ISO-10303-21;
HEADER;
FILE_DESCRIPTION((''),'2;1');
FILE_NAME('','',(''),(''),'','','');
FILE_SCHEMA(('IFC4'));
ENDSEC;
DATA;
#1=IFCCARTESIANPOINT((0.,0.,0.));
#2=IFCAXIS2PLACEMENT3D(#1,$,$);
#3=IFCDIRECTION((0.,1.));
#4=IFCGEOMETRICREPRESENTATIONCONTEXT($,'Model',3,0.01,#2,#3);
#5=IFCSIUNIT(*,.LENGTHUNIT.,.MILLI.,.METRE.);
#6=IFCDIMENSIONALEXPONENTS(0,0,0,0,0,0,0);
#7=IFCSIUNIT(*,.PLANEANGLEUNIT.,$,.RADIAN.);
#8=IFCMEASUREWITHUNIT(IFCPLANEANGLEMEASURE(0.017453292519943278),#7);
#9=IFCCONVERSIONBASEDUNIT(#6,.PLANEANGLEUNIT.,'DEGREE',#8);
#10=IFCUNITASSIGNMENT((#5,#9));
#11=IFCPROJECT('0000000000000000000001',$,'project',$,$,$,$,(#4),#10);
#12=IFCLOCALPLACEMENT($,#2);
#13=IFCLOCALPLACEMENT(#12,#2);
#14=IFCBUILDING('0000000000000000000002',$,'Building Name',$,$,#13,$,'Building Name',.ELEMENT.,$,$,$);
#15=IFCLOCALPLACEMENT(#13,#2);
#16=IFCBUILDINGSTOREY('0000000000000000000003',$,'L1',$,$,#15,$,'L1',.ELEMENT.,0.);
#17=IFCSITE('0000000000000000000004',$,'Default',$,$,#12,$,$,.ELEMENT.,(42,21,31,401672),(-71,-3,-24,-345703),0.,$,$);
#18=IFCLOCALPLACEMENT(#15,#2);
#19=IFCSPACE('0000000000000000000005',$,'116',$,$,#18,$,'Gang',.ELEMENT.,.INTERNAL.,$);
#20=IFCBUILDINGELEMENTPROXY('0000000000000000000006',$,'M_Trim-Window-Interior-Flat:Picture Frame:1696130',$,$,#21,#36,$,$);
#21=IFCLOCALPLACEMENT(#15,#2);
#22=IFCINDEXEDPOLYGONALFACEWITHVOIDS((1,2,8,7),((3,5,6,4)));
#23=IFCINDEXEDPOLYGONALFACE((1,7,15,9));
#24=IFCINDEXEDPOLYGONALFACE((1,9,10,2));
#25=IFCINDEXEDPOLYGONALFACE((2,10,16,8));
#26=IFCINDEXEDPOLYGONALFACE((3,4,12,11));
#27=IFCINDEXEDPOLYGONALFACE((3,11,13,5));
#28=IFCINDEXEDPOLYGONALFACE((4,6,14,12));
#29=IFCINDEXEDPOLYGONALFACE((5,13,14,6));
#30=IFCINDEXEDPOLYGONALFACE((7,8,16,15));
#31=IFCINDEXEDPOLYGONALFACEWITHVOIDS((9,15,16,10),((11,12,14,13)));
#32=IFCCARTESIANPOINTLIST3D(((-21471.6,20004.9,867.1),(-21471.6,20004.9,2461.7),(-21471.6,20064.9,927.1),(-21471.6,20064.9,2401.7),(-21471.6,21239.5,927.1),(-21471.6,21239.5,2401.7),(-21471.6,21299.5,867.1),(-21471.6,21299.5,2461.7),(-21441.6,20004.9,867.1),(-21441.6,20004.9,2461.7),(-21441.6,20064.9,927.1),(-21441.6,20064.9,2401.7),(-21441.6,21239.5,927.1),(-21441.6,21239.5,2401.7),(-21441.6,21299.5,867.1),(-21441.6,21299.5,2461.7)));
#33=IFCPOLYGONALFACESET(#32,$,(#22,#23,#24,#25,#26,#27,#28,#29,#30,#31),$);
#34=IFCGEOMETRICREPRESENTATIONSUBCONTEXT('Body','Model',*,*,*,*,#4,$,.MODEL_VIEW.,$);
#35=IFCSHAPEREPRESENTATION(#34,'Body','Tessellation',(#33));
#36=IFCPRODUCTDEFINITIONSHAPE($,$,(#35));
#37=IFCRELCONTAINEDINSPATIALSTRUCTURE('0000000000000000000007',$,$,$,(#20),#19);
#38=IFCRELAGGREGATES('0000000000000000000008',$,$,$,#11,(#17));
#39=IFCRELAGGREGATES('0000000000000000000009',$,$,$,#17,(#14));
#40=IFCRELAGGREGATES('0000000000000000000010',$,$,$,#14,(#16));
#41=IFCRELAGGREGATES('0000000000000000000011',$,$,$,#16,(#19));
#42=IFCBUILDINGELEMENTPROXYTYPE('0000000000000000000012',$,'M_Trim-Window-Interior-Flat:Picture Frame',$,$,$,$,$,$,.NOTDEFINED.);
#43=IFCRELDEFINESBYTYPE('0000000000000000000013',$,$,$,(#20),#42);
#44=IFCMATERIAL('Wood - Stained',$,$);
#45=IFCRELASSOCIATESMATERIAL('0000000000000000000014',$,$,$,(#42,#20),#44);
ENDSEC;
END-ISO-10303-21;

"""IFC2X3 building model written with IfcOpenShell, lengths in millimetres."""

from ifc_helpers import new_model, entity, si_unit, converted_unit, direction, frame, origin, place, context, subcontext, project, spatial, polyline, outline, extrude, source, transform, mapped, material, type_object, type_shapes, element, save


model = new_model("IFC2X3")

# Units and contexts
model_context = context("Model", 3, precision=0.01, world=origin(), true_north=direction((0.0, 1.0)))
body_context = subcontext(model_context, "Body", "Model", "MODEL_VIEW")
ifc_project = project(units=[si_unit("LENGTHUNIT", "METRE", prefix="MILLI"), converted_unit("PLANEANGLEUNIT", "DEGREE", entity("IfcPlaneAngleMeasure", 0.017453292519943278), si_unit("PLANEANGLEUNIT", "RADIAN"), dimensions=[0, 0, 0, 0, 0, 0, 0])], contexts=[model_context])

# Site, building, storey
site_placement = place(None, origin())
site = spatial("IfcSite", under=ifc_project, at=site_placement, Name="Default", CompositionType="ELEMENT", RefLatitude=(42, 21, 31, 401672), RefLongitude=(-71, -3, -24, -345703), RefElevation=0.0)
building_placement = place(site_placement, origin())
building = spatial("IfcBuilding", under=site, at=building_placement, Name="Building Name", LongName="Building Name", CompositionType="ELEMENT")
storey_placement = place(building_placement, origin())
storey = spatial("IfcBuildingStorey", under=building, at=storey_placement, Name="L1", LongName="L1", CompositionType="ELEMENT", Elevation=0.0)

# Shared definitions
ifc_material_1 = material(Name="Wood - Stained")

# Shared definitions
building_element_proxy_type_1 = type_object("IfcBuildingElementProxyType", Name="M_Trim-Window-Interior-Flat:Picture Frame", PredefinedType="NOTDEFINED", material=ifc_material_1)
shared_shape_1 = source(origin(), body_context, "Body", "SweptSolid", [
    extrude(outline(polyline([(-647.3, -797.3), (647.3, -797.3), (647.3, 797.3), (-647.3, 797.3), (-647.3, -797.3)]), holes=[polyline([(-587.3, -737.3), (-587.3, 737.3), (587.3, 737.3), (587.3, -737.3), (-587.3, -737.3)])]), frame((0.0, -750.0, 0.0), z_axis=(0.0, 0.0, 1.0), x_axis=(-1.0, 0.0, 0.0)), (0.0, 0.0, 1.0), 30.0),
])
type_shapes(building_element_proxy_type_1, [shared_shape_1])

# Shared definitions
space_1_placement = place(storey_placement, origin())
space_1 = spatial("IfcSpace", under=storey, at=space_1_placement, Name="116", LongName="Gang", CompositionType="ELEMENT", InteriorOrExteriorSpace="INTERNAL")

# Building element proxy
proxy_1_placement = place(space_1_placement, frame((-21471.6, 20652.2, 2414.4), z_axis=(1.0, 0.0, 0.0), x_axis=(0.0, 1.0, 0.0)))
element("IfcBuildingElementProxy", 1, at=proxy_1_placement, inside=space_1, type_object=building_element_proxy_type_1, material=ifc_material_1, Name="M_Trim-Window-Interior-Flat:Picture Frame:1696130", context=body_context, shape_type="MappedRepresentation", body=[
    mapped(shared_shape_1, transform((0.0, 0.0, 0.0), scale=1.0)),
])

save(model, "model.ifc")
